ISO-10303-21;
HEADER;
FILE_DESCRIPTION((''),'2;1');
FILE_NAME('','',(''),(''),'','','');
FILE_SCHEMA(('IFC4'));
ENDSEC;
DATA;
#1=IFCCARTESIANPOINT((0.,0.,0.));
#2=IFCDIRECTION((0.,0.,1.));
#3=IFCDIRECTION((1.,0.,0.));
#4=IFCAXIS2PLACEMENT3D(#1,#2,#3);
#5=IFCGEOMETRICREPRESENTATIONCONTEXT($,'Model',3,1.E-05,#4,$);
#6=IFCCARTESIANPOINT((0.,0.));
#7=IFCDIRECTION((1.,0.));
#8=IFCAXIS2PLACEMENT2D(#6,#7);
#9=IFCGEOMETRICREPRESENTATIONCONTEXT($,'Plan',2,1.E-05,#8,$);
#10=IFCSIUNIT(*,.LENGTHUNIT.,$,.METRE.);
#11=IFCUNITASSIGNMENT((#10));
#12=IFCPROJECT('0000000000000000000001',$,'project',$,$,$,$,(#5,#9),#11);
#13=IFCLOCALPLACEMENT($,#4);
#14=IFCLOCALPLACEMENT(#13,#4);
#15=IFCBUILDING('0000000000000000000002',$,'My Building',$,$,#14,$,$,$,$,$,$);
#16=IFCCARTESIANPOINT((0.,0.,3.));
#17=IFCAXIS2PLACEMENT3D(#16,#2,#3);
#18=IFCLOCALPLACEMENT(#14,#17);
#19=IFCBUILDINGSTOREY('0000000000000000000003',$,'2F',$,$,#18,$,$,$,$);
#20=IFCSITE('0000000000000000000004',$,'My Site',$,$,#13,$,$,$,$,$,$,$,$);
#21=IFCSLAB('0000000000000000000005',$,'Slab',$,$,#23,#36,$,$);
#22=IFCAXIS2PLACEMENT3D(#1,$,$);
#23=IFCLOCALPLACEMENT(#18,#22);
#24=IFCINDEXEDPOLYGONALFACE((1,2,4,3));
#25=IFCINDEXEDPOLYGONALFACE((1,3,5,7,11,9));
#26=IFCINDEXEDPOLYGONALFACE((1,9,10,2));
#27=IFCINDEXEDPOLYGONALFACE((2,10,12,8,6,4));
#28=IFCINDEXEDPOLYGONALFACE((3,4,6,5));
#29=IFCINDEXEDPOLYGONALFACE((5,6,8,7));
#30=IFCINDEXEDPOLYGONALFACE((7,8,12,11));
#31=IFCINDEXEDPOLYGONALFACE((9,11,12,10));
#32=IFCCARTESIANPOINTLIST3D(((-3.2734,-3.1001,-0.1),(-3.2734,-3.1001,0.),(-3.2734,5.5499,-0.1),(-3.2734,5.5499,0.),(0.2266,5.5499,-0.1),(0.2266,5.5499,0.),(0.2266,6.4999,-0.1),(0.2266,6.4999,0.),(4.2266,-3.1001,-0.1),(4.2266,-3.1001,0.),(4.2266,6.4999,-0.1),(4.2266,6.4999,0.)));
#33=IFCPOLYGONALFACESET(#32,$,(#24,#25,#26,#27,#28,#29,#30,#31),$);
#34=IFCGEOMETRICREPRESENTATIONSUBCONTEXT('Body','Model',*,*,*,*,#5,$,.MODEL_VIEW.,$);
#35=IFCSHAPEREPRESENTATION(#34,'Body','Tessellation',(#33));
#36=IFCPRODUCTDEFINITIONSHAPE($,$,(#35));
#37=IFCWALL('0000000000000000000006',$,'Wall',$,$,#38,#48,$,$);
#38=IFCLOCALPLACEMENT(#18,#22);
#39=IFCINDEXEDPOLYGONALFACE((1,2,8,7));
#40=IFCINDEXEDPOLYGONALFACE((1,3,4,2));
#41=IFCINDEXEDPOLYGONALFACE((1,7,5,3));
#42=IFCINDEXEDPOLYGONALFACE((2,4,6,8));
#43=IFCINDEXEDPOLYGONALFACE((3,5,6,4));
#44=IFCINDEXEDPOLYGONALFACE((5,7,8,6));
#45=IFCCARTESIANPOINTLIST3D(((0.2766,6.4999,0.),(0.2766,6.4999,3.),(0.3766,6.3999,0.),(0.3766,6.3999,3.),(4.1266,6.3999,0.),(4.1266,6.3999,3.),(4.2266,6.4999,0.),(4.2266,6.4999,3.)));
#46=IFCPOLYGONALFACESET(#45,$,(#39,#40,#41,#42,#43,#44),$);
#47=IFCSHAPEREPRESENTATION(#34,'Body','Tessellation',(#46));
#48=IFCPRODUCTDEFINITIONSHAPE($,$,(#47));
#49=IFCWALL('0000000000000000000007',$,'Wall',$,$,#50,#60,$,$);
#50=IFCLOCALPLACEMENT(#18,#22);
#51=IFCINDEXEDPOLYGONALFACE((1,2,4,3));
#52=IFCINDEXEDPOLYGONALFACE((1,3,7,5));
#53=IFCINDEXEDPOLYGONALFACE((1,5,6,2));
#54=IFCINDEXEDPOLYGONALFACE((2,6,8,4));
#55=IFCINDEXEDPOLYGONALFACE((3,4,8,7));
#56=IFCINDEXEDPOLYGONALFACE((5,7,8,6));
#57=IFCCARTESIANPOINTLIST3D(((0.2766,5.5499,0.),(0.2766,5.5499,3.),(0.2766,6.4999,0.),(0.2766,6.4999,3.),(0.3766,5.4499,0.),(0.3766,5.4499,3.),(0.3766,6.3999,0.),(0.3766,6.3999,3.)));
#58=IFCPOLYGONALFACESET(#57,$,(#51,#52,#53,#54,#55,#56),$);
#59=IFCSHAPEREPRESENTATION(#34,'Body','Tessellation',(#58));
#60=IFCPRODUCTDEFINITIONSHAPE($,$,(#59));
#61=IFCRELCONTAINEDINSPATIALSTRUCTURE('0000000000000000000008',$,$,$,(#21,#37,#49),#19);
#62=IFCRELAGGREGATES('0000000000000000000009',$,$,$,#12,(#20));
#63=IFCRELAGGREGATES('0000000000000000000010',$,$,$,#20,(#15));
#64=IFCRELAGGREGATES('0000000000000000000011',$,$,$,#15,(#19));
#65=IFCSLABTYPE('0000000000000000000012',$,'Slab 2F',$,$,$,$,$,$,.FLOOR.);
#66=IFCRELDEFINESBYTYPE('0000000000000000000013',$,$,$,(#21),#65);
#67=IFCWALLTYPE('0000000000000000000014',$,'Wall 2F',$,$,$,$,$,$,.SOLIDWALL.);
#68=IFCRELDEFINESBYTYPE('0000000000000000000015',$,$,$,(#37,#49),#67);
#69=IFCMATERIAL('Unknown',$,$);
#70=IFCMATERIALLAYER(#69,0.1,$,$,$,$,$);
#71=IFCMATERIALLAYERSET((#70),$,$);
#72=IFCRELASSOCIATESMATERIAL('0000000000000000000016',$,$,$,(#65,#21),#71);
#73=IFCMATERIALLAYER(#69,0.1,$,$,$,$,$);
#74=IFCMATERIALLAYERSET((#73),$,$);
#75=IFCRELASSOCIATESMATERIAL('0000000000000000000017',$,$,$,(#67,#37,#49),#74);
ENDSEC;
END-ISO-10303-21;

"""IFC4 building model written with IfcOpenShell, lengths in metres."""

from ifc_helpers import new_model, si_unit, frame, origin_with_axes, origin_2d_with_axis, place, context, subcontext, project, spatial, line, indexed_curve, outline, extrude, material, layer, layer_set, layer_usage, type_object, element, save


model = new_model("IFC4")

# Units and contexts
model_context = context("Model", 3, precision=1e-05, world=origin_with_axes())
plan_context = context("Plan", 2, precision=1e-05, world=origin_2d_with_axis())
body_context_1 = subcontext(model_context, "Body", "Model", "MODEL_VIEW")
ifc_project = project(units=[si_unit("LENGTHUNIT", "METRE")], contexts=[model_context, plan_context])

# Site, building, storey
site_placement = place(None, origin_with_axes())
site = spatial("IfcSite", under=ifc_project, at=site_placement, Name="My Site")
building_placement = place(site_placement, origin_with_axes())
building = spatial("IfcBuilding", under=site, at=building_placement, Name="My Building")
storey_placement = place(building_placement, frame((0.0, 0.0, 3.0), z_axis=(0.0, 0.0, 1.0), x_axis=(1.0, 0.0, 0.0)))
storey = spatial("IfcBuildingStorey", under=building, at=storey_placement, Name="2F")

# Slab
ifc_material = material(Name="Unknown")
ifc_layer_1 = layer(ifc_material, 0.1)
ifc_layer_set_1 = layer_set([ifc_layer_1])
ifc_layer_usage_1 = layer_usage(ifc_layer_set_1, "AXIS3", "POSITIVE", -0.1)
slab_type = type_object("IfcSlabType", Name="Slab 2F", PredefinedType="FLOOR", material=ifc_layer_set_1)
slab_placement = place(storey_placement, frame((4.2266, -3.1001, 0.0), z_axis=(0.0, 0.0, 1.0), x_axis=(1.0, 0.0, 0.0)))
element("IfcSlab", 1, at=slab_placement, inside=storey, type_object=slab_type, material=ifc_layer_usage_1, Name="Slab", context=body_context_1, shape_type="SweptSolid", body=[
    extrude(outline(indexed_curve([(0.0, 0.0), (-7.5, 0.0), (-7.5, 8.65), (-4.0, 8.65), (-4.0, 9.6), (0.0, 9.6), (0.0, 0.0)])), frame((0.0, 0.0, -0.1), z_axis=(0.0, 0.0, 1.0), x_axis=(1.0, 0.0, 0.0)), (0.0, 0.0, 1.0), 0.1),
])

# Walls
ifc_layer_2 = layer(ifc_material, 0.1)
ifc_layer_set_2 = layer_set([ifc_layer_2])
ifc_layer_usage_2 = layer_usage(ifc_layer_set_2, "AXIS2", "POSITIVE", 0.0)
wall_type = type_object("IfcWallType", Name="Wall 2F", PredefinedType="SOLIDWALL", material=ifc_layer_set_2)
wall_1_placement = place(storey_placement, frame((4.2266, 6.4999, 0.0), z_axis=(0.0, 0.0, 1.0), x_axis=(-1.0, 0.0, 0.0)))
element("IfcWall", 2, at=wall_1_placement, inside=storey, type_object=wall_type, material=ifc_layer_usage_2, Name="Wall", context=body_context_1, shape_type="SweptSolid", body=[
    extrude(outline(indexed_curve([(0.0, 0.0), (0.1, 0.1), (3.85, 0.1), (3.95, 0.0)], segments=[line(1, 2, 3, 4, 1)])), origin_with_axes(), (0.0, 0.0, 1.0), 3.0),
])
ifc_layer_usage_3 = layer_usage(ifc_layer_set_2, "AXIS2", "POSITIVE", 0.0)
wall_2_placement = place(storey_placement, frame((0.2766, 6.4999, 0.0), z_axis=(0.0, 0.0, 1.0), x_axis=(0.0, -1.0, 0.0)))
element("IfcWall", 3, at=wall_2_placement, inside=storey, type_object=wall_type, material=ifc_layer_usage_3, Name="Wall", context=body_context_1, shape_type="SweptSolid", body=[
    extrude(outline(indexed_curve([(0.0, 0.0), (0.1, 0.1), (1.05, 0.1), (0.95, 0.0)], segments=[line(1, 2, 3, 4, 1)])), origin_with_axes(), (0.0, 0.0, 1.0), 3.0),
])

save(model, "model.ifc")
